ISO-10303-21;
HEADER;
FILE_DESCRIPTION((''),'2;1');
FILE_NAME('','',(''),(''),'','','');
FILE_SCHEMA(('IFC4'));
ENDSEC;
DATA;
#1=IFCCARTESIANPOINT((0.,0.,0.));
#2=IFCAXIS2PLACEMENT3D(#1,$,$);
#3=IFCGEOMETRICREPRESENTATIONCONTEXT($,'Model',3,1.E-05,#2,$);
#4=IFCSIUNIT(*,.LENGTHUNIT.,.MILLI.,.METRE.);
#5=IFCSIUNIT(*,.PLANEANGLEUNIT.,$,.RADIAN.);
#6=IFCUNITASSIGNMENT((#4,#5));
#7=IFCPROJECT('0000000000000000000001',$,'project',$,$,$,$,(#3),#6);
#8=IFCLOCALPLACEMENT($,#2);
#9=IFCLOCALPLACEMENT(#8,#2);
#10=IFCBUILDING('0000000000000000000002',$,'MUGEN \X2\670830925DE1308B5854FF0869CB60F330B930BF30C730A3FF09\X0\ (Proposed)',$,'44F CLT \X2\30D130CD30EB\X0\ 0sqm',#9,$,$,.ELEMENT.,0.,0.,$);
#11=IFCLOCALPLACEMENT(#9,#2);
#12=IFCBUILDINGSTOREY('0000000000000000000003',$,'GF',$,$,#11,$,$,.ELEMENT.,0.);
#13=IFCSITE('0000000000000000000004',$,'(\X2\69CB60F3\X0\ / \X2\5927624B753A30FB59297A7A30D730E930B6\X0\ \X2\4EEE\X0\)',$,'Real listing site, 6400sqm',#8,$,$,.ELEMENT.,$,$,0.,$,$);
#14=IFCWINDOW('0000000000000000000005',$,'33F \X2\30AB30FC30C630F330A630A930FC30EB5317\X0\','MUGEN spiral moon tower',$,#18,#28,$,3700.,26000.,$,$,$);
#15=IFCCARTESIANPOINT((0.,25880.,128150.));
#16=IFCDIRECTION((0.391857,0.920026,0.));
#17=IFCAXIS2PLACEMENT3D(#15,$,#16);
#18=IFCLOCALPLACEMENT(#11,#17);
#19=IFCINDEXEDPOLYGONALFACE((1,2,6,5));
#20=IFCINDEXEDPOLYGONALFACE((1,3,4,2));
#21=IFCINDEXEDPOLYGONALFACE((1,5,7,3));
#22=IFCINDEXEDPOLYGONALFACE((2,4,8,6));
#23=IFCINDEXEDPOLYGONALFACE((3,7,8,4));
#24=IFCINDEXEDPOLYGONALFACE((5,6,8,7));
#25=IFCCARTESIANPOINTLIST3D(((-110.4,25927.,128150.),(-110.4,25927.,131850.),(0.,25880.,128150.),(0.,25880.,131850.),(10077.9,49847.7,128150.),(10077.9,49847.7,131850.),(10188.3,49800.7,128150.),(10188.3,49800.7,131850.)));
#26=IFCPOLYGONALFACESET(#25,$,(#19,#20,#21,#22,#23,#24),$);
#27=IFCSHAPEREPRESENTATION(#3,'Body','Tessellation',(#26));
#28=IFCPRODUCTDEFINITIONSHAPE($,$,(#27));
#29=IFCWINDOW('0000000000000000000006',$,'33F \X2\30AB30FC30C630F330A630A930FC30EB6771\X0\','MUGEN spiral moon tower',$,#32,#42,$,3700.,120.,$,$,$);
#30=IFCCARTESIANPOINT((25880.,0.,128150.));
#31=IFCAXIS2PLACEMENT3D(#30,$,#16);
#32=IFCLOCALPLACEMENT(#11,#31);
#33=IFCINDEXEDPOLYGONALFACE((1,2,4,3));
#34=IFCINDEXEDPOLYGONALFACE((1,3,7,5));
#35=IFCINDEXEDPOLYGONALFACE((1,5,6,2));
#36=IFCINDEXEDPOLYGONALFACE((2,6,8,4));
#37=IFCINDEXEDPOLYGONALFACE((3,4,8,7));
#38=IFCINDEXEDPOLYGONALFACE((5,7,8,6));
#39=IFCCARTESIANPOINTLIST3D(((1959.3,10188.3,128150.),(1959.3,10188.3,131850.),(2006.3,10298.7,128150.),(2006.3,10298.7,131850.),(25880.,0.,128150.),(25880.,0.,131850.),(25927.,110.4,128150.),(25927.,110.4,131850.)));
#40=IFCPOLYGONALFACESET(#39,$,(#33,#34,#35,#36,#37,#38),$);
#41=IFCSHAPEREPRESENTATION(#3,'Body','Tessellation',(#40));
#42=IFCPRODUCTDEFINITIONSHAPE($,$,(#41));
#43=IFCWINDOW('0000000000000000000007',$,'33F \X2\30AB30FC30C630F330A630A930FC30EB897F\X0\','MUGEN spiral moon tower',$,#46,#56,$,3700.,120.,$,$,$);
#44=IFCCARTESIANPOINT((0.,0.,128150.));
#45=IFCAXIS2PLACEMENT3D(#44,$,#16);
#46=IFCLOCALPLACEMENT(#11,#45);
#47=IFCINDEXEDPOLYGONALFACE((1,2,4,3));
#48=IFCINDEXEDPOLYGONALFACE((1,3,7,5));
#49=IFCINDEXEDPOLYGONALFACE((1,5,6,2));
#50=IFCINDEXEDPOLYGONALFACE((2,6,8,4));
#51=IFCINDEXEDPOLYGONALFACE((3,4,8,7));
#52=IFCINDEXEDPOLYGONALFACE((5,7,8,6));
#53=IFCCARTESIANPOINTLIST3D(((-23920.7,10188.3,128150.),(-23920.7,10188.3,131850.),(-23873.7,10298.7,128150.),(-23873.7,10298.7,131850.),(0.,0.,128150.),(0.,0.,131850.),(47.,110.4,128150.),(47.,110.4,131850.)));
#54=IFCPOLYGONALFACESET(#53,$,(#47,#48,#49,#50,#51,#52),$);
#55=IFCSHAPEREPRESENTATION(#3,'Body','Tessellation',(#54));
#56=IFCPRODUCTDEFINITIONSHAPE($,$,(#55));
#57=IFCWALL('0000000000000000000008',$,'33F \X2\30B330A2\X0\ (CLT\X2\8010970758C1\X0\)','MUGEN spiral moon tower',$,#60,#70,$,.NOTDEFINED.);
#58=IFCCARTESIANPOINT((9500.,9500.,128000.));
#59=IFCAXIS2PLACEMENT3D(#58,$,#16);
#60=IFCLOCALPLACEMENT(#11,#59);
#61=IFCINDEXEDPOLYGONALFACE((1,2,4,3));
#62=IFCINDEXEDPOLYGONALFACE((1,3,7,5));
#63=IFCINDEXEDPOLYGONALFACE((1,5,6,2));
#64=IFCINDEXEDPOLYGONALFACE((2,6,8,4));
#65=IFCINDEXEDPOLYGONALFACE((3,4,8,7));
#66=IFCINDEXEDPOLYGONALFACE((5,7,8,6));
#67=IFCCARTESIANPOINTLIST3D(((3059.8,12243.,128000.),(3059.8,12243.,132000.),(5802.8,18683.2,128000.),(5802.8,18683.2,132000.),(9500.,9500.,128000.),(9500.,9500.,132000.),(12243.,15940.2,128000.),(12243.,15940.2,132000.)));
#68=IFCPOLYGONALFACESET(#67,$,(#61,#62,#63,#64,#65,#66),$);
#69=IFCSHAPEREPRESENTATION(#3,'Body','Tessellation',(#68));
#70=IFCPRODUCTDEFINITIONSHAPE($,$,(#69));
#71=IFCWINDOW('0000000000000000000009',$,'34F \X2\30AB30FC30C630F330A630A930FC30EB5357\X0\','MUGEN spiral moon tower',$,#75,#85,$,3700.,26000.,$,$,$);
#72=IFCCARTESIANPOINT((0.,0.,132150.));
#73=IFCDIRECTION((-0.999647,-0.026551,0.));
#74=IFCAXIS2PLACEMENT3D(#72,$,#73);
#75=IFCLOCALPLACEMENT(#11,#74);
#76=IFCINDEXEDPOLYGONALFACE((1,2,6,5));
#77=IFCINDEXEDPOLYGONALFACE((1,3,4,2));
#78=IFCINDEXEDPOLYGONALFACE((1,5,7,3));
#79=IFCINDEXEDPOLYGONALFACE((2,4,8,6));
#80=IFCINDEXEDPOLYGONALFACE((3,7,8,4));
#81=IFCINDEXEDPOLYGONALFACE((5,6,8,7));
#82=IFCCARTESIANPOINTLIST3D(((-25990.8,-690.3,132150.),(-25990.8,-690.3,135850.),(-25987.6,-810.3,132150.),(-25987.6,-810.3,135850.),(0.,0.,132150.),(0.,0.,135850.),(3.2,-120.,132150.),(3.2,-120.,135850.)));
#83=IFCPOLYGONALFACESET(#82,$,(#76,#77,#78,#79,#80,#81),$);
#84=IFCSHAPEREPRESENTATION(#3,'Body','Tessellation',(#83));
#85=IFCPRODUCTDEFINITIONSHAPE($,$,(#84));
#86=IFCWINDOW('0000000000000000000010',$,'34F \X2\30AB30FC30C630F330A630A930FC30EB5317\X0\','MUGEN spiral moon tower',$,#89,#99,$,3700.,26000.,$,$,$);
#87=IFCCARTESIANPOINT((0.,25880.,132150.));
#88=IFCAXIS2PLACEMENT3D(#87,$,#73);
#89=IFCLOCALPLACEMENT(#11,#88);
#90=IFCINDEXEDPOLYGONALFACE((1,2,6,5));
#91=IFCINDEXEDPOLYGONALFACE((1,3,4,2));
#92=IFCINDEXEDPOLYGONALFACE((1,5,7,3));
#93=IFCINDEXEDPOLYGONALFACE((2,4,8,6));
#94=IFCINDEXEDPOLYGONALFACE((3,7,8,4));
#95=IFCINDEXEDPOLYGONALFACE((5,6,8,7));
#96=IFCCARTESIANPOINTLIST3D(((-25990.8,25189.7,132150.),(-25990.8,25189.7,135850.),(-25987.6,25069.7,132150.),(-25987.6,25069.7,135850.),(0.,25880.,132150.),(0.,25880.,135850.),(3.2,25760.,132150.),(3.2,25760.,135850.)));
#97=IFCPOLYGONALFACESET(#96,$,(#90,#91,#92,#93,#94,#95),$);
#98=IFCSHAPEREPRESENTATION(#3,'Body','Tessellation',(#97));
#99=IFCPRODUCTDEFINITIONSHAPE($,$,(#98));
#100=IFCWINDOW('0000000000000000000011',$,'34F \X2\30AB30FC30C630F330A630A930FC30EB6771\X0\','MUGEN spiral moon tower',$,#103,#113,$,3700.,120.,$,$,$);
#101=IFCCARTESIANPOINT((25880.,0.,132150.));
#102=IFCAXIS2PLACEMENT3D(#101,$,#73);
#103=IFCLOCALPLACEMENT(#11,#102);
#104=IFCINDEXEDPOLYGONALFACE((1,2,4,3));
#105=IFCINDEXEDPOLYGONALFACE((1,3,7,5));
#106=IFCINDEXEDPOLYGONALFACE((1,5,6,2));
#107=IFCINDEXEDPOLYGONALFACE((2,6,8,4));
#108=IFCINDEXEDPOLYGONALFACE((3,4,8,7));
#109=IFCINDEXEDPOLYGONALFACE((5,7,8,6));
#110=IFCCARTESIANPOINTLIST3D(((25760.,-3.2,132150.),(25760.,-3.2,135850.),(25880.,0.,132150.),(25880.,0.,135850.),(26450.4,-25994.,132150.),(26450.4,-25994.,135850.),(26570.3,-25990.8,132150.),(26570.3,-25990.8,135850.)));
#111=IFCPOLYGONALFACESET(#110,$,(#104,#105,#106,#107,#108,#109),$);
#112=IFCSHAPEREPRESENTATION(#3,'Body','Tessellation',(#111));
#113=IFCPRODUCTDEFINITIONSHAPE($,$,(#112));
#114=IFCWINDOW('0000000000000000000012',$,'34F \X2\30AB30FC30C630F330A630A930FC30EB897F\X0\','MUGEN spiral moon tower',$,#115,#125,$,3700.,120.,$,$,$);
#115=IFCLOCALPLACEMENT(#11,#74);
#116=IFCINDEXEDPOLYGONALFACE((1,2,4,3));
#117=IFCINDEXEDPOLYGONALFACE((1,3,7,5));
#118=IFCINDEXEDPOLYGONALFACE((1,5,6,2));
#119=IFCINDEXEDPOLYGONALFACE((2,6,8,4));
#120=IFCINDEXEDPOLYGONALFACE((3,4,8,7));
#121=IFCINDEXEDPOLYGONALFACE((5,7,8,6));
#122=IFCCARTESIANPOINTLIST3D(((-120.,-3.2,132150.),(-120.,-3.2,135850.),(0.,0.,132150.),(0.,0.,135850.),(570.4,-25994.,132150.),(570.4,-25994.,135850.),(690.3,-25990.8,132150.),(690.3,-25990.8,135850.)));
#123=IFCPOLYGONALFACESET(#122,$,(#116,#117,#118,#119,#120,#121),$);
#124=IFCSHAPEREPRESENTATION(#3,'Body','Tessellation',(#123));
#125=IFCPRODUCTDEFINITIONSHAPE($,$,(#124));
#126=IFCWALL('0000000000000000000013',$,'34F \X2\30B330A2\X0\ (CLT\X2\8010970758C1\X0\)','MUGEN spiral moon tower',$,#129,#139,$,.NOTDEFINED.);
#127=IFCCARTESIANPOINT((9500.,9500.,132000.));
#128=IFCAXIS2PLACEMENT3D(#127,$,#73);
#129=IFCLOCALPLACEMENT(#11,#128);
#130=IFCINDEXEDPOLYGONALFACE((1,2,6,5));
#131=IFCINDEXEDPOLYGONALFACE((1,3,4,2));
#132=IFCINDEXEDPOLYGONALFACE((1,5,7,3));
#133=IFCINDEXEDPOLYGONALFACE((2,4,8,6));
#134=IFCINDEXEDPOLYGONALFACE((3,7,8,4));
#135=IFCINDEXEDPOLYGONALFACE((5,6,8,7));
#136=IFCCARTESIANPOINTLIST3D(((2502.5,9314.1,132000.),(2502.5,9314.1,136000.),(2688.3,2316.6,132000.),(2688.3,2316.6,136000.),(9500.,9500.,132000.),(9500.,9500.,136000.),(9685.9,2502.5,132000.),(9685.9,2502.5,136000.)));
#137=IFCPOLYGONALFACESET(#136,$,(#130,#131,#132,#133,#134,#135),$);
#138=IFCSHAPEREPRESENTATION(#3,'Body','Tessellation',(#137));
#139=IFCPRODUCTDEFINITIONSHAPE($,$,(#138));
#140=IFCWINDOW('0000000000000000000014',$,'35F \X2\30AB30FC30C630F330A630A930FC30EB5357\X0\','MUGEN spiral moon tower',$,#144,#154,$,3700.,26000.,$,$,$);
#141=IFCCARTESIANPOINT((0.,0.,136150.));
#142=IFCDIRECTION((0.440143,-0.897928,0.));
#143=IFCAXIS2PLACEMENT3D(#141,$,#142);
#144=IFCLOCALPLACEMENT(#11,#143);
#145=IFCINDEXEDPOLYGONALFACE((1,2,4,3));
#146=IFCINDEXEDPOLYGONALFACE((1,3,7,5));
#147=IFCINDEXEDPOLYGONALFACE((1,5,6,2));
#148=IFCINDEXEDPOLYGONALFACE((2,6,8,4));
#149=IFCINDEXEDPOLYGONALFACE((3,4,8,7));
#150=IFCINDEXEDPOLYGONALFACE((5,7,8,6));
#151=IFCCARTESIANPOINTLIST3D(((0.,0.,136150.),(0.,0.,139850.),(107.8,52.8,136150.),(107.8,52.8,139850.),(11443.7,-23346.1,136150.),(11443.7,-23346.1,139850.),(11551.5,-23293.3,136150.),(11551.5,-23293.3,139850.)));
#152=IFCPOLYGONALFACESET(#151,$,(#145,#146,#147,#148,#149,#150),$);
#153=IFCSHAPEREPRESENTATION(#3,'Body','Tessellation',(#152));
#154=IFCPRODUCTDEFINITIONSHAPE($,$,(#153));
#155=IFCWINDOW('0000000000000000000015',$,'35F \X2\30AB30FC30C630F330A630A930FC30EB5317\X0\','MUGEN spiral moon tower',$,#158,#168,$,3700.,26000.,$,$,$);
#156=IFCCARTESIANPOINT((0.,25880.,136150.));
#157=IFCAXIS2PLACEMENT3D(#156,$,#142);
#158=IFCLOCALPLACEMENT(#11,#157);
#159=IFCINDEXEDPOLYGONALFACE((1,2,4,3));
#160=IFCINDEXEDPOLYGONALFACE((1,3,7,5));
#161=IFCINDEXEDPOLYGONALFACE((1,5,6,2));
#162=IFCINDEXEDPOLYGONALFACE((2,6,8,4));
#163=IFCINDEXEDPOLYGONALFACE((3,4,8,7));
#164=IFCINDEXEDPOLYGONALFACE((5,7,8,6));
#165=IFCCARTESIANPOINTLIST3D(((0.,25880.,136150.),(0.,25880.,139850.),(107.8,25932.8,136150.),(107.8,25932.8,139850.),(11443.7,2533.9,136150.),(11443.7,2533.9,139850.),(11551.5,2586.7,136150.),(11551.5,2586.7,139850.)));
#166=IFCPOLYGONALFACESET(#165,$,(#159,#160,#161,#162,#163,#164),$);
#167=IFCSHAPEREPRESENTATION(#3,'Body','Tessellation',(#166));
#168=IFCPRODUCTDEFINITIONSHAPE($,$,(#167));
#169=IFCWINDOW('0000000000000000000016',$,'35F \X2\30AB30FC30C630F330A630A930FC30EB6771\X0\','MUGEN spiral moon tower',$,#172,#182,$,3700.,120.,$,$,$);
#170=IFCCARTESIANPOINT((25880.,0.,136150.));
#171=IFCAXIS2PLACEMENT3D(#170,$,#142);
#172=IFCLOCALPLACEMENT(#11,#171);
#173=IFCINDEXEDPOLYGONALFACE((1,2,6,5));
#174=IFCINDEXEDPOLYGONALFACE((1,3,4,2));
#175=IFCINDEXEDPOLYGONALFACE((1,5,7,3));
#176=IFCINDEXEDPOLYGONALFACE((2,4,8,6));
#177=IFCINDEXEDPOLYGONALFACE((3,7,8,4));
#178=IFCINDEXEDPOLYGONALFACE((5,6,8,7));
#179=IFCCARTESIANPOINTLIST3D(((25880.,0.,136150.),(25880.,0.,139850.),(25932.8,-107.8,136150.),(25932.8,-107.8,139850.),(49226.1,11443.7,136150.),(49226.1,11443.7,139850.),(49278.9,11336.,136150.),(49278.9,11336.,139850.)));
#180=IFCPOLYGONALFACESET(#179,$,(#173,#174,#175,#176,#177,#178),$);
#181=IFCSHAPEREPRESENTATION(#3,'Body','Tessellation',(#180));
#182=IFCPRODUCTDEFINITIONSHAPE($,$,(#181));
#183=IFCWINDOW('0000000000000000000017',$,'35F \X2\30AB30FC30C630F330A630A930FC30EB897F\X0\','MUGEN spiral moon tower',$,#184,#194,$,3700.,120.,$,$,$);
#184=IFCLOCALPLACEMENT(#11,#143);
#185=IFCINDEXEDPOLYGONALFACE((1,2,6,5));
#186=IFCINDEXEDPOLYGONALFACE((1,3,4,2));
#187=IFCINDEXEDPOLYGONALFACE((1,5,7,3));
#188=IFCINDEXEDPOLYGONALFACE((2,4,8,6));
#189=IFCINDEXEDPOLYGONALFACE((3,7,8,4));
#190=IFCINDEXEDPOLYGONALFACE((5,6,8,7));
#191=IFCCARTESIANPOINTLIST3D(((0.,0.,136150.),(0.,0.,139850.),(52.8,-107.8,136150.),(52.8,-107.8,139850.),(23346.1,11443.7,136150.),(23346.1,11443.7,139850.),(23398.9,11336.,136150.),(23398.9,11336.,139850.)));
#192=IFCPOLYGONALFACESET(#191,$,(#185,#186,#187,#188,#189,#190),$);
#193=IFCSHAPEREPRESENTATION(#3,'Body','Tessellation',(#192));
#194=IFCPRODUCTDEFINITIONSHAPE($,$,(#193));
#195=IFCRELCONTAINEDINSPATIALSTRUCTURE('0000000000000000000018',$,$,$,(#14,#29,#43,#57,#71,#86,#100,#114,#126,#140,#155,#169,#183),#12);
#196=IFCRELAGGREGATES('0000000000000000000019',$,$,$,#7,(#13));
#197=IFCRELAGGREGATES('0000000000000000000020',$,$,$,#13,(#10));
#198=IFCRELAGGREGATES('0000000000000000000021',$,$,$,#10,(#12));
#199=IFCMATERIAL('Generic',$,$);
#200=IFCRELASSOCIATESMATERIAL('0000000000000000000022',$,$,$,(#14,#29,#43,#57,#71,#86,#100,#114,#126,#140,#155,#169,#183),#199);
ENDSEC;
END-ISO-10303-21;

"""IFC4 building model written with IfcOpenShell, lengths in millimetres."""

from ifc_helpers import new_model, si_unit, frame, frame_2d, origin, place, context, project, spatial, rectangle, extrude, material, element, save


model = new_model("IFC4")

# Units and contexts
model_context = context("Model", 3, precision=1e-05, world=origin())
ifc_project = project(units=[si_unit("LENGTHUNIT", "METRE", prefix="MILLI"), si_unit("PLANEANGLEUNIT", "RADIAN")], contexts=[model_context])

# Site, building, storey
site_placement = place(None, origin())
site = spatial("IfcSite", under=ifc_project, at=site_placement, Name="(構想 / 大手町・天空プラザ 仮)", ObjectType="Real listing site, 6400sqm", CompositionType="ELEMENT", RefElevation=0.0)
building_placement = place(site_placement, origin())
building = spatial("IfcBuilding", under=site, at=building_placement, Name="MUGEN 月を巡る塔（構想スタディ） (Proposed)", ObjectType="44F CLT パネル 0sqm", CompositionType="ELEMENT", ElevationOfRefHeight=0.0, ElevationOfTerrain=0.0)
storey_placement = place(building_placement, origin())
storey = spatial("IfcBuildingStorey", under=building, at=storey_placement, Name="GF", CompositionType="ELEMENT", Elevation=0.0)

# Shared definitions
ifc_material = material(Name="Generic")

# Windows
window_1_placement = place(storey_placement, frame((0.0, 25880.0, 128150.0), x_axis=(0.391857, 0.920026, 0.0)))
element("IfcWindow", 1, at=window_1_placement, inside=storey, material=ifc_material, Name="33F カーテンウォール北", Description="MUGEN spiral moon tower", OverallHeight=3700.0, OverallWidth=26000.0, context=model_context, shape_type="SweptSolid", body=[
    extrude(rectangle(XDim=26000.0, YDim=120.0, at=frame_2d((13000.0, 60.0))), frame((0.0, 25880.0, 128150.0), x_axis=(0.391857, 0.920026, 0.0)), (0.0, 0.0, 1.0), 3700.0),
])
window_2_placement = place(storey_placement, frame((25880.0, 0.0, 128150.0), x_axis=(0.391857, 0.920026, 0.0)))
element("IfcWindow", 2, at=window_2_placement, inside=storey, material=ifc_material, Name="33F カーテンウォール東", Description="MUGEN spiral moon tower", OverallHeight=3700.0, OverallWidth=120.0, context=model_context, shape_type="SweptSolid", body=[
    extrude(rectangle(XDim=120.0, YDim=26000.0, at=frame_2d((60.0, 13000.0))), frame((25880.0, 0.0, 128150.0), x_axis=(0.391857, 0.920026, 0.0)), (0.0, 0.0, 1.0), 3700.0),
])
window_3_placement = place(storey_placement, frame((0.0, 0.0, 128150.0), x_axis=(0.391857, 0.920026, 0.0)))
element("IfcWindow", 3, at=window_3_placement, inside=storey, material=ifc_material, Name="33F カーテンウォール西", Description="MUGEN spiral moon tower", OverallHeight=3700.0, OverallWidth=120.0, context=model_context, shape_type="SweptSolid", body=[
    extrude(rectangle(XDim=120.0, YDim=26000.0, at=frame_2d((60.0, 13000.0))), frame((0.0, 0.0, 128150.0), x_axis=(0.391857, 0.920026, 0.0)), (0.0, 0.0, 1.0), 3700.0),
])

# Wall
wall_1_placement = place(storey_placement, frame((9500.0, 9500.0, 128000.0), x_axis=(0.391857, 0.920026, 0.0)))
element("IfcWall", 4, at=wall_1_placement, inside=storey, material=ifc_material, Name="33F コア (CLT耐震壁)", Description="MUGEN spiral moon tower", PredefinedType="NOTDEFINED", context=model_context, shape_type="SweptSolid", body=[
    extrude(rectangle(XDim=7000.0, YDim=7000.0, at=frame_2d((3500.0, 3500.0))), frame((9500.0, 9500.0, 128000.0), x_axis=(0.391857, 0.920026, 0.0)), (0.0, 0.0, 1.0), 4000.0),
])

# Windows
window_4_placement = place(storey_placement, frame((0.0, 0.0, 132150.0), x_axis=(-0.999647, -0.026551, 0.0)))
element("IfcWindow", 5, at=window_4_placement, inside=storey, material=ifc_material, Name="34F カーテンウォール南", Description="MUGEN spiral moon tower", OverallHeight=3700.0, OverallWidth=26000.0, context=model_context, shape_type="SweptSolid", body=[
    extrude(rectangle(XDim=26000.0, YDim=120.0, at=frame_2d((13000.0, 60.0))), frame((0.0, 0.0, 132150.0), x_axis=(-0.999647, -0.026551, 0.0)), (0.0, 0.0, 1.0), 3700.0),
])
window_5_placement = place(storey_placement, frame((0.0, 25880.0, 132150.0), x_axis=(-0.999647, -0.026551, 0.0)))
element("IfcWindow", 6, at=window_5_placement, inside=storey, material=ifc_material, Name="34F カーテンウォール北", Description="MUGEN spiral moon tower", OverallHeight=3700.0, OverallWidth=26000.0, context=model_context, shape_type="SweptSolid", body=[
    extrude(rectangle(XDim=26000.0, YDim=120.0, at=frame_2d((13000.0, 60.0))), frame((0.0, 25880.0, 132150.0), x_axis=(-0.999647, -0.026551, 0.0)), (0.0, 0.0, 1.0), 3700.0),
])
window_6_placement = place(storey_placement, frame((25880.0, 0.0, 132150.0), x_axis=(-0.999647, -0.026551, 0.0)))
element("IfcWindow", 7, at=window_6_placement, inside=storey, material=ifc_material, Name="34F カーテンウォール東", Description="MUGEN spiral moon tower", OverallHeight=3700.0, OverallWidth=120.0, context=model_context, shape_type="SweptSolid", body=[
    extrude(rectangle(XDim=120.0, YDim=26000.0, at=frame_2d((60.0, 13000.0))), frame((25880.0, 0.0, 132150.0), x_axis=(-0.999647, -0.026551, 0.0)), (0.0, 0.0, 1.0), 3700.0),
])
window_7_placement = place(storey_placement, frame((0.0, 0.0, 132150.0), x_axis=(-0.999647, -0.026551, 0.0)))
element("IfcWindow", 8, at=window_7_placement, inside=storey, material=ifc_material, Name="34F カーテンウォール西", Description="MUGEN spiral moon tower", OverallHeight=3700.0, OverallWidth=120.0, context=model_context, shape_type="SweptSolid", body=[
    extrude(rectangle(XDim=120.0, YDim=26000.0, at=frame_2d((60.0, 13000.0))), frame((0.0, 0.0, 132150.0), x_axis=(-0.999647, -0.026551, 0.0)), (0.0, 0.0, 1.0), 3700.0),
])

# Wall
wall_2_placement = place(storey_placement, frame((9500.0, 9500.0, 132000.0), x_axis=(-0.999647, -0.026551, 0.0)))
element("IfcWall", 9, at=wall_2_placement, inside=storey, material=ifc_material, Name="34F コア (CLT耐震壁)", Description="MUGEN spiral moon tower", PredefinedType="NOTDEFINED", context=model_context, shape_type="SweptSolid", body=[
    extrude(rectangle(XDim=7000.0, YDim=7000.0, at=frame_2d((3500.0, 3500.0))), frame((9500.0, 9500.0, 132000.0), x_axis=(-0.999647, -0.026551, 0.0)), (0.0, 0.0, 1.0), 4000.0),
])

# Windows
window_8_placement = place(storey_placement, frame((0.0, 0.0, 136150.0), x_axis=(0.440143, -0.897928, 0.0)))
element("IfcWindow", 10, at=window_8_placement, inside=storey, material=ifc_material, Name="35F カーテンウォール南", Description="MUGEN spiral moon tower", OverallHeight=3700.0, OverallWidth=26000.0, context=model_context, shape_type="SweptSolid", body=[
    extrude(rectangle(XDim=26000.0, YDim=120.0, at=frame_2d((13000.0, 60.0))), frame((0.0, 0.0, 136150.0), x_axis=(0.440143, -0.897928, 0.0)), (0.0, 0.0, 1.0), 3700.0),
])
window_9_placement = place(storey_placement, frame((0.0, 25880.0, 136150.0), x_axis=(0.440143, -0.897928, 0.0)))
element("IfcWindow", 11, at=window_9_placement, inside=storey, material=ifc_material, Name="35F カーテンウォール北", Description="MUGEN spiral moon tower", OverallHeight=3700.0, OverallWidth=26000.0, context=model_context, shape_type="SweptSolid", body=[
    extrude(rectangle(XDim=26000.0, YDim=120.0, at=frame_2d((13000.0, 60.0))), frame((0.0, 25880.0, 136150.0), x_axis=(0.440143, -0.897928, 0.0)), (0.0, 0.0, 1.0), 3700.0),
])
window_10_placement = place(storey_placement, frame((25880.0, 0.0, 136150.0), x_axis=(0.440143, -0.897928, 0.0)))
element("IfcWindow", 12, at=window_10_placement, inside=storey, material=ifc_material, Name="35F カーテンウォール東", Description="MUGEN spiral moon tower", OverallHeight=3700.0, OverallWidth=120.0, context=model_context, shape_type="SweptSolid", body=[
    extrude(rectangle(XDim=120.0, YDim=26000.0, at=frame_2d((60.0, 13000.0))), frame((25880.0, 0.0, 136150.0), x_axis=(0.440143, -0.897928, 0.0)), (0.0, 0.0, 1.0), 3700.0),
])
window_11_placement = place(storey_placement, frame((0.0, 0.0, 136150.0), x_axis=(0.440143, -0.897928, 0.0)))
element("IfcWindow", 13, at=window_11_placement, inside=storey, material=ifc_material, Name="35F カーテンウォール西", Description="MUGEN spiral moon tower", OverallHeight=3700.0, OverallWidth=120.0, context=model_context, shape_type="SweptSolid", body=[
    extrude(rectangle(XDim=120.0, YDim=26000.0, at=frame_2d((60.0, 13000.0))), frame((0.0, 0.0, 136150.0), x_axis=(0.440143, -0.897928, 0.0)), (0.0, 0.0, 1.0), 3700.0),
])

save(model, "model.ifc")
